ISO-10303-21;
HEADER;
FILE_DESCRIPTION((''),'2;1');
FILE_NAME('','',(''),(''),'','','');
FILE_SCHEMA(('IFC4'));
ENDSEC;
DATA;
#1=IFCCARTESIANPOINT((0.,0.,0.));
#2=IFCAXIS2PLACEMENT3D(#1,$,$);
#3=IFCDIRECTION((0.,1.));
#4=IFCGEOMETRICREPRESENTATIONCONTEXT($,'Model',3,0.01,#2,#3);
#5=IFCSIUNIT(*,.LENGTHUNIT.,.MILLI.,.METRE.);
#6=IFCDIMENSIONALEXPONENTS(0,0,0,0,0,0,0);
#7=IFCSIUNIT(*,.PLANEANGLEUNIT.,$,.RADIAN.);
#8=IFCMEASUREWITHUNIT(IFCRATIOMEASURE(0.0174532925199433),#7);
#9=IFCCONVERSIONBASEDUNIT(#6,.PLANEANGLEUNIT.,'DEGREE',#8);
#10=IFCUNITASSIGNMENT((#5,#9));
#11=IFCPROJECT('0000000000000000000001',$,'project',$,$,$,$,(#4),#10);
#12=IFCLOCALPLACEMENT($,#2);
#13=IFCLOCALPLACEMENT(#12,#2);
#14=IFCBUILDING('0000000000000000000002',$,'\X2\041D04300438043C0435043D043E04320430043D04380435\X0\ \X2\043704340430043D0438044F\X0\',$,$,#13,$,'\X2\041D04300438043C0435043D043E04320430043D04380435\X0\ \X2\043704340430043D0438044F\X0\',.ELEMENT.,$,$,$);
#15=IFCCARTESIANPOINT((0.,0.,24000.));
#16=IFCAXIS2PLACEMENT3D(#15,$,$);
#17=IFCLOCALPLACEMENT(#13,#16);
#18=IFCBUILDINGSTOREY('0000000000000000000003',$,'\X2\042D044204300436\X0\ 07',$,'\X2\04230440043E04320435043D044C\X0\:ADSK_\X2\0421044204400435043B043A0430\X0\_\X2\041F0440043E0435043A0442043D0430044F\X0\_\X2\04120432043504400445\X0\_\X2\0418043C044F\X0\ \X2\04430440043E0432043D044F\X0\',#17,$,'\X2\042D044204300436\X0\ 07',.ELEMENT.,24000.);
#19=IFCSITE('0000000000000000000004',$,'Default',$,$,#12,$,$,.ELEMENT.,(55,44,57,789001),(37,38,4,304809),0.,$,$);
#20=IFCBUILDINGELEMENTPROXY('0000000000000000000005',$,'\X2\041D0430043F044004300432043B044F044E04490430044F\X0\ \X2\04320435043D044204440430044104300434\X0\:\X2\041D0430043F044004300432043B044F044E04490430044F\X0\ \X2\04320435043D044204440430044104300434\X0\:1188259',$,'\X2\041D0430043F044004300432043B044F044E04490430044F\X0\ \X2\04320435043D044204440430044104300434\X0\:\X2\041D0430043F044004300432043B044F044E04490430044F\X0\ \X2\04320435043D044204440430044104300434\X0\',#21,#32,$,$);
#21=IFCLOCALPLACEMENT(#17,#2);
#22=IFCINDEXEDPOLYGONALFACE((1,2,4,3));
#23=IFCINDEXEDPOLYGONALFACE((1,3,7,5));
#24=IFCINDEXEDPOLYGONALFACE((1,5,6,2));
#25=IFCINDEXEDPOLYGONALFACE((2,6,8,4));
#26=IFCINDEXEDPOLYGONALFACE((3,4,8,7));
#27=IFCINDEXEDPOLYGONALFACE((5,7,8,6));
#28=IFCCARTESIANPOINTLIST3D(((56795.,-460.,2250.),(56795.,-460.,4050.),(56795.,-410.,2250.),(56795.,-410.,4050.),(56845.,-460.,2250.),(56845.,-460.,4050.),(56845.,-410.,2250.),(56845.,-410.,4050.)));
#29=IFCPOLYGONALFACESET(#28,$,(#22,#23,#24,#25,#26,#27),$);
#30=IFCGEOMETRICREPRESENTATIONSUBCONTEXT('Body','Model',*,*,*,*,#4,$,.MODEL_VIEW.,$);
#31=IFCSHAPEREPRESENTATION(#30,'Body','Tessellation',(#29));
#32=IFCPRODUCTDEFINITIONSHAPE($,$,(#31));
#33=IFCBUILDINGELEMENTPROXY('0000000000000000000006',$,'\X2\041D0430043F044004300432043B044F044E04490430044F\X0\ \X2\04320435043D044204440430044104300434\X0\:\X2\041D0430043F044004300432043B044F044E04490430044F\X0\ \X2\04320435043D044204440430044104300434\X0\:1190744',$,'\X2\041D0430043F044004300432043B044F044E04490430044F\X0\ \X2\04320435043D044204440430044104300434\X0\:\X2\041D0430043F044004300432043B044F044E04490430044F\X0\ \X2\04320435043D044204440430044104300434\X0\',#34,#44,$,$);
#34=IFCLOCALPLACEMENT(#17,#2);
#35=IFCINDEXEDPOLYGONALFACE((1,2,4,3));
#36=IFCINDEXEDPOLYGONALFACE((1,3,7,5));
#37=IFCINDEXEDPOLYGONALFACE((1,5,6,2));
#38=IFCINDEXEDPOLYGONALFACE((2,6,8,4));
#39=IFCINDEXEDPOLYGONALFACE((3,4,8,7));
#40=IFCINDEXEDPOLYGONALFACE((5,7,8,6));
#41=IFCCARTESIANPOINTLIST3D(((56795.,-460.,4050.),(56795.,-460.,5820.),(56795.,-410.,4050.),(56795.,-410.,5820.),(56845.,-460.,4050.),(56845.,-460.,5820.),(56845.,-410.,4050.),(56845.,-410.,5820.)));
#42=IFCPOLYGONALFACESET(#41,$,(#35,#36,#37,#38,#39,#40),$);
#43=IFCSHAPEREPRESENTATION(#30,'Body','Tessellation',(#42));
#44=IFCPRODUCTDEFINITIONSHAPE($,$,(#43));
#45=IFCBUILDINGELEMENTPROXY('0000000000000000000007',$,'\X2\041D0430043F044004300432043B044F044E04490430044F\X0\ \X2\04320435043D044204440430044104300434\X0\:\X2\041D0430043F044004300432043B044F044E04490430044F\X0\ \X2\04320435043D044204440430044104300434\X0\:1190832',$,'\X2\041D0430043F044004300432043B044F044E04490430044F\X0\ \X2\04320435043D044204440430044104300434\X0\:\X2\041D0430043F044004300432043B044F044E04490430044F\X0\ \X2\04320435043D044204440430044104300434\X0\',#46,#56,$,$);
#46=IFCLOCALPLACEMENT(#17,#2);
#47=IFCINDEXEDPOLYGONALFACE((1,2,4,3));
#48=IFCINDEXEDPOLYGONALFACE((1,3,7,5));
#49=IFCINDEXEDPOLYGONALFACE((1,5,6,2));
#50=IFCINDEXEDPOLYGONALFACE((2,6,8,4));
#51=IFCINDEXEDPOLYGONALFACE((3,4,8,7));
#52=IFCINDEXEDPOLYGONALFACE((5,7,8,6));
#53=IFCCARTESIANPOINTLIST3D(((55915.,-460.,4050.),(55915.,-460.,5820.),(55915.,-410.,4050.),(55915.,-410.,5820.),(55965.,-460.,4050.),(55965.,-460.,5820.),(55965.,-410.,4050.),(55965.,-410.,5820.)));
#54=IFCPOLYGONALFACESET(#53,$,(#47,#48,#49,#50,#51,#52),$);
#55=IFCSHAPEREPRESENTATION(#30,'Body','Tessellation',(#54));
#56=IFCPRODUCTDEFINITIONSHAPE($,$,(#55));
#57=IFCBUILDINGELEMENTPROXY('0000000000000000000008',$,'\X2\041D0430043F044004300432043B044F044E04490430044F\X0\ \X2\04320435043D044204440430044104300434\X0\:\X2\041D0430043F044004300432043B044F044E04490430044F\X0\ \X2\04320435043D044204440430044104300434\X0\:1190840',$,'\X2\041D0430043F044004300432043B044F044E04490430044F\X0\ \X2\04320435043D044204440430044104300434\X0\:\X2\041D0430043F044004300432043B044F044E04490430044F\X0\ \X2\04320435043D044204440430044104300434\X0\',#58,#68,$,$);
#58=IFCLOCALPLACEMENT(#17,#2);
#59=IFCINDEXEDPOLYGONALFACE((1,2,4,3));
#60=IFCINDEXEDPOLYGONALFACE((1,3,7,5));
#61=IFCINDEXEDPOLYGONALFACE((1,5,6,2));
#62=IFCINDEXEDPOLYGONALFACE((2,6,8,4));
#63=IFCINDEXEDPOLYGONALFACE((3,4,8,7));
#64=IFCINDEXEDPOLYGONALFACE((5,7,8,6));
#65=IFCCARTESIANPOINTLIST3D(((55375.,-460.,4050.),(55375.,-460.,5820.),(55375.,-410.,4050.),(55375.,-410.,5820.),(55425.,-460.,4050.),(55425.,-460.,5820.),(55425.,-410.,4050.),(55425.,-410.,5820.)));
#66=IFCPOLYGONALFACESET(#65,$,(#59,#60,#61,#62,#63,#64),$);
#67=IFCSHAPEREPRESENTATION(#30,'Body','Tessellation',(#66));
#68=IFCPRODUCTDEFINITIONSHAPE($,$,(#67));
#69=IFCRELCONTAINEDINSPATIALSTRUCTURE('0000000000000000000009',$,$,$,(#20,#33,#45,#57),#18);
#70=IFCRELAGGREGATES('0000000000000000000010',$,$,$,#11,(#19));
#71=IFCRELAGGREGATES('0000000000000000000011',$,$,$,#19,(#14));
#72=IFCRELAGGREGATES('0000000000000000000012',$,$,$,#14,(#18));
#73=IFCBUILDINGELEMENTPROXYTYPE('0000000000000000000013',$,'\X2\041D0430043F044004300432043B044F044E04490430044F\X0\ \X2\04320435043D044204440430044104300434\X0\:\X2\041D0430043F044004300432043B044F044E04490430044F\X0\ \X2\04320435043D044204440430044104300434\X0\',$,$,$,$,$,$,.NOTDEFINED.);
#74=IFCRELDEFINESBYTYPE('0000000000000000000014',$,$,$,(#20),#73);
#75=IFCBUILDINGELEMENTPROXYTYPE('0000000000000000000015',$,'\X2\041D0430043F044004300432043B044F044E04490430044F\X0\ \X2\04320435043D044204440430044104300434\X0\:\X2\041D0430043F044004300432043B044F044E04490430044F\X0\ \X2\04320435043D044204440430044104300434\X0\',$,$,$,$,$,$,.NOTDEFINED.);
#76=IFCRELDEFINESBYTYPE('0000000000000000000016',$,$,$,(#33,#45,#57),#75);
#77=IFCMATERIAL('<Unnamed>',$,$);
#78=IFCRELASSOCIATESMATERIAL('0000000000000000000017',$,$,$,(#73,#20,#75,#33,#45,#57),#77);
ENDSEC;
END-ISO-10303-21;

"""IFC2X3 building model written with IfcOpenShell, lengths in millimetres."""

from ifc_helpers import new_model, entity, si_unit, converted_unit, direction, frame, origin, origin_2d_with_axis, place, context, subcontext, project, spatial, rectangle, extrude, source, transform, mapped, material, type_object, type_shapes, element, save


model = new_model("IFC2X3")

# Units and contexts
model_context = context("Model", 3, precision=0.01, world=origin(), true_north=direction((0.0, 1.0)))
body_context = subcontext(model_context, "Body", "Model", "MODEL_VIEW")
ifc_project = project(units=[si_unit("LENGTHUNIT", "METRE", prefix="MILLI"), converted_unit("PLANEANGLEUNIT", "DEGREE", entity("IfcRatioMeasure", 0.0174532925199433), si_unit("PLANEANGLEUNIT", "RADIAN"), dimensions=[0, 0, 0, 0, 0, 0, 0])], contexts=[model_context])

# Site, building, storey
site_placement = place(None, origin())
site = spatial("IfcSite", under=ifc_project, at=site_placement, Name="Default", CompositionType="ELEMENT", RefLatitude=(55, 44, 57, 789001), RefLongitude=(37, 38, 4, 304809), RefElevation=0.0)
building_placement = place(site_placement, origin())
building = spatial("IfcBuilding", under=site, at=building_placement, Name="Наименование здания", LongName="Наименование здания", CompositionType="ELEMENT")
storey_placement = place(building_placement, frame((0.0, 0.0, 24000.0)))
storey = spatial("IfcBuildingStorey", under=building, at=storey_placement, Name="Этаж 07", ObjectType="Уровень:ADSK_Стрелка_Проектная_Вверх_Имя уровня", LongName="Этаж 07", CompositionType="ELEMENT", Elevation=24000.0)

# Building element proxies
ifc_material_1 = material(Name="<Unnamed>")
building_element_proxy_type_1 = type_object("IfcBuildingElementProxyType", Name="Направляющая вентфасад:Направляющая вентфасад", PredefinedType="NOTDEFINED", material=ifc_material_1)
shared_shape_1 = source(origin(), body_context, "Body", "SweptSolid", [
    extrude(rectangle(XDim=50.0, YDim=50.0, at=origin_2d_with_axis()), frame((25.0, -25.0, 0.0), z_axis=(0.0, 0.0, 1.0), x_axis=(-1.0, 0.0, 0.0)), (0.0, 0.0, 1.0), 1800.0),
])
type_shapes(building_element_proxy_type_1, [shared_shape_1])
proxy_1_placement = place(storey_placement, frame((56795.0, -410.0, 2250.0)))
element("IfcBuildingElementProxy", 1, at=proxy_1_placement, inside=storey, type_object=building_element_proxy_type_1, material=ifc_material_1, Name="Направляющая вентфасад:Направляющая вентфасад:1188259", ObjectType="Направляющая вентфасад:Направляющая вентфасад", context=body_context, shape_type="MappedRepresentation", body=[
    mapped(shared_shape_1, transform((0.0, 0.0, 0.0), scale=1.0)),
])
building_element_proxy_type_2 = type_object("IfcBuildingElementProxyType", Name="Направляющая вентфасад:Направляющая вентфасад", PredefinedType="NOTDEFINED", material=ifc_material_1)
shared_shape_2 = source(origin(), body_context, "Body", "SweptSolid", [
    extrude(rectangle(XDim=50.0, YDim=50.0, at=origin_2d_with_axis()), frame((25.0, -25.0, 0.0), z_axis=(0.0, 0.0, 1.0), x_axis=(-1.0, 0.0, 0.0)), (0.0, 0.0, 1.0), 1770.0),
])
type_shapes(building_element_proxy_type_2, [shared_shape_2])
for number, where, name in (
    (2, (56795.0, -410.0, 4050.0), "Направляющая вентфасад:Направляющая вентфасад:1190744"),
    (3, (55915.0, -410.0, 4050.0), "Направляющая вентфасад:Направляющая вентфасад:1190832"),
    (4, (55375.0, -410.0, 4050.0), "Направляющая вентфасад:Направляющая вентфасад:1190840"),
):
    element("IfcBuildingElementProxy", number, at=place(storey_placement, frame(where)), inside=storey, type_object=building_element_proxy_type_2, material=ifc_material_1, Name=name, ObjectType="Направляющая вентфасад:Направляющая вентфасад", context=body_context, shape_type="MappedRepresentation", body=[
        mapped(shared_shape_2, transform((0.0, 0.0, 0.0), scale=1.0)),
    ])

save(model, "model.ifc")
